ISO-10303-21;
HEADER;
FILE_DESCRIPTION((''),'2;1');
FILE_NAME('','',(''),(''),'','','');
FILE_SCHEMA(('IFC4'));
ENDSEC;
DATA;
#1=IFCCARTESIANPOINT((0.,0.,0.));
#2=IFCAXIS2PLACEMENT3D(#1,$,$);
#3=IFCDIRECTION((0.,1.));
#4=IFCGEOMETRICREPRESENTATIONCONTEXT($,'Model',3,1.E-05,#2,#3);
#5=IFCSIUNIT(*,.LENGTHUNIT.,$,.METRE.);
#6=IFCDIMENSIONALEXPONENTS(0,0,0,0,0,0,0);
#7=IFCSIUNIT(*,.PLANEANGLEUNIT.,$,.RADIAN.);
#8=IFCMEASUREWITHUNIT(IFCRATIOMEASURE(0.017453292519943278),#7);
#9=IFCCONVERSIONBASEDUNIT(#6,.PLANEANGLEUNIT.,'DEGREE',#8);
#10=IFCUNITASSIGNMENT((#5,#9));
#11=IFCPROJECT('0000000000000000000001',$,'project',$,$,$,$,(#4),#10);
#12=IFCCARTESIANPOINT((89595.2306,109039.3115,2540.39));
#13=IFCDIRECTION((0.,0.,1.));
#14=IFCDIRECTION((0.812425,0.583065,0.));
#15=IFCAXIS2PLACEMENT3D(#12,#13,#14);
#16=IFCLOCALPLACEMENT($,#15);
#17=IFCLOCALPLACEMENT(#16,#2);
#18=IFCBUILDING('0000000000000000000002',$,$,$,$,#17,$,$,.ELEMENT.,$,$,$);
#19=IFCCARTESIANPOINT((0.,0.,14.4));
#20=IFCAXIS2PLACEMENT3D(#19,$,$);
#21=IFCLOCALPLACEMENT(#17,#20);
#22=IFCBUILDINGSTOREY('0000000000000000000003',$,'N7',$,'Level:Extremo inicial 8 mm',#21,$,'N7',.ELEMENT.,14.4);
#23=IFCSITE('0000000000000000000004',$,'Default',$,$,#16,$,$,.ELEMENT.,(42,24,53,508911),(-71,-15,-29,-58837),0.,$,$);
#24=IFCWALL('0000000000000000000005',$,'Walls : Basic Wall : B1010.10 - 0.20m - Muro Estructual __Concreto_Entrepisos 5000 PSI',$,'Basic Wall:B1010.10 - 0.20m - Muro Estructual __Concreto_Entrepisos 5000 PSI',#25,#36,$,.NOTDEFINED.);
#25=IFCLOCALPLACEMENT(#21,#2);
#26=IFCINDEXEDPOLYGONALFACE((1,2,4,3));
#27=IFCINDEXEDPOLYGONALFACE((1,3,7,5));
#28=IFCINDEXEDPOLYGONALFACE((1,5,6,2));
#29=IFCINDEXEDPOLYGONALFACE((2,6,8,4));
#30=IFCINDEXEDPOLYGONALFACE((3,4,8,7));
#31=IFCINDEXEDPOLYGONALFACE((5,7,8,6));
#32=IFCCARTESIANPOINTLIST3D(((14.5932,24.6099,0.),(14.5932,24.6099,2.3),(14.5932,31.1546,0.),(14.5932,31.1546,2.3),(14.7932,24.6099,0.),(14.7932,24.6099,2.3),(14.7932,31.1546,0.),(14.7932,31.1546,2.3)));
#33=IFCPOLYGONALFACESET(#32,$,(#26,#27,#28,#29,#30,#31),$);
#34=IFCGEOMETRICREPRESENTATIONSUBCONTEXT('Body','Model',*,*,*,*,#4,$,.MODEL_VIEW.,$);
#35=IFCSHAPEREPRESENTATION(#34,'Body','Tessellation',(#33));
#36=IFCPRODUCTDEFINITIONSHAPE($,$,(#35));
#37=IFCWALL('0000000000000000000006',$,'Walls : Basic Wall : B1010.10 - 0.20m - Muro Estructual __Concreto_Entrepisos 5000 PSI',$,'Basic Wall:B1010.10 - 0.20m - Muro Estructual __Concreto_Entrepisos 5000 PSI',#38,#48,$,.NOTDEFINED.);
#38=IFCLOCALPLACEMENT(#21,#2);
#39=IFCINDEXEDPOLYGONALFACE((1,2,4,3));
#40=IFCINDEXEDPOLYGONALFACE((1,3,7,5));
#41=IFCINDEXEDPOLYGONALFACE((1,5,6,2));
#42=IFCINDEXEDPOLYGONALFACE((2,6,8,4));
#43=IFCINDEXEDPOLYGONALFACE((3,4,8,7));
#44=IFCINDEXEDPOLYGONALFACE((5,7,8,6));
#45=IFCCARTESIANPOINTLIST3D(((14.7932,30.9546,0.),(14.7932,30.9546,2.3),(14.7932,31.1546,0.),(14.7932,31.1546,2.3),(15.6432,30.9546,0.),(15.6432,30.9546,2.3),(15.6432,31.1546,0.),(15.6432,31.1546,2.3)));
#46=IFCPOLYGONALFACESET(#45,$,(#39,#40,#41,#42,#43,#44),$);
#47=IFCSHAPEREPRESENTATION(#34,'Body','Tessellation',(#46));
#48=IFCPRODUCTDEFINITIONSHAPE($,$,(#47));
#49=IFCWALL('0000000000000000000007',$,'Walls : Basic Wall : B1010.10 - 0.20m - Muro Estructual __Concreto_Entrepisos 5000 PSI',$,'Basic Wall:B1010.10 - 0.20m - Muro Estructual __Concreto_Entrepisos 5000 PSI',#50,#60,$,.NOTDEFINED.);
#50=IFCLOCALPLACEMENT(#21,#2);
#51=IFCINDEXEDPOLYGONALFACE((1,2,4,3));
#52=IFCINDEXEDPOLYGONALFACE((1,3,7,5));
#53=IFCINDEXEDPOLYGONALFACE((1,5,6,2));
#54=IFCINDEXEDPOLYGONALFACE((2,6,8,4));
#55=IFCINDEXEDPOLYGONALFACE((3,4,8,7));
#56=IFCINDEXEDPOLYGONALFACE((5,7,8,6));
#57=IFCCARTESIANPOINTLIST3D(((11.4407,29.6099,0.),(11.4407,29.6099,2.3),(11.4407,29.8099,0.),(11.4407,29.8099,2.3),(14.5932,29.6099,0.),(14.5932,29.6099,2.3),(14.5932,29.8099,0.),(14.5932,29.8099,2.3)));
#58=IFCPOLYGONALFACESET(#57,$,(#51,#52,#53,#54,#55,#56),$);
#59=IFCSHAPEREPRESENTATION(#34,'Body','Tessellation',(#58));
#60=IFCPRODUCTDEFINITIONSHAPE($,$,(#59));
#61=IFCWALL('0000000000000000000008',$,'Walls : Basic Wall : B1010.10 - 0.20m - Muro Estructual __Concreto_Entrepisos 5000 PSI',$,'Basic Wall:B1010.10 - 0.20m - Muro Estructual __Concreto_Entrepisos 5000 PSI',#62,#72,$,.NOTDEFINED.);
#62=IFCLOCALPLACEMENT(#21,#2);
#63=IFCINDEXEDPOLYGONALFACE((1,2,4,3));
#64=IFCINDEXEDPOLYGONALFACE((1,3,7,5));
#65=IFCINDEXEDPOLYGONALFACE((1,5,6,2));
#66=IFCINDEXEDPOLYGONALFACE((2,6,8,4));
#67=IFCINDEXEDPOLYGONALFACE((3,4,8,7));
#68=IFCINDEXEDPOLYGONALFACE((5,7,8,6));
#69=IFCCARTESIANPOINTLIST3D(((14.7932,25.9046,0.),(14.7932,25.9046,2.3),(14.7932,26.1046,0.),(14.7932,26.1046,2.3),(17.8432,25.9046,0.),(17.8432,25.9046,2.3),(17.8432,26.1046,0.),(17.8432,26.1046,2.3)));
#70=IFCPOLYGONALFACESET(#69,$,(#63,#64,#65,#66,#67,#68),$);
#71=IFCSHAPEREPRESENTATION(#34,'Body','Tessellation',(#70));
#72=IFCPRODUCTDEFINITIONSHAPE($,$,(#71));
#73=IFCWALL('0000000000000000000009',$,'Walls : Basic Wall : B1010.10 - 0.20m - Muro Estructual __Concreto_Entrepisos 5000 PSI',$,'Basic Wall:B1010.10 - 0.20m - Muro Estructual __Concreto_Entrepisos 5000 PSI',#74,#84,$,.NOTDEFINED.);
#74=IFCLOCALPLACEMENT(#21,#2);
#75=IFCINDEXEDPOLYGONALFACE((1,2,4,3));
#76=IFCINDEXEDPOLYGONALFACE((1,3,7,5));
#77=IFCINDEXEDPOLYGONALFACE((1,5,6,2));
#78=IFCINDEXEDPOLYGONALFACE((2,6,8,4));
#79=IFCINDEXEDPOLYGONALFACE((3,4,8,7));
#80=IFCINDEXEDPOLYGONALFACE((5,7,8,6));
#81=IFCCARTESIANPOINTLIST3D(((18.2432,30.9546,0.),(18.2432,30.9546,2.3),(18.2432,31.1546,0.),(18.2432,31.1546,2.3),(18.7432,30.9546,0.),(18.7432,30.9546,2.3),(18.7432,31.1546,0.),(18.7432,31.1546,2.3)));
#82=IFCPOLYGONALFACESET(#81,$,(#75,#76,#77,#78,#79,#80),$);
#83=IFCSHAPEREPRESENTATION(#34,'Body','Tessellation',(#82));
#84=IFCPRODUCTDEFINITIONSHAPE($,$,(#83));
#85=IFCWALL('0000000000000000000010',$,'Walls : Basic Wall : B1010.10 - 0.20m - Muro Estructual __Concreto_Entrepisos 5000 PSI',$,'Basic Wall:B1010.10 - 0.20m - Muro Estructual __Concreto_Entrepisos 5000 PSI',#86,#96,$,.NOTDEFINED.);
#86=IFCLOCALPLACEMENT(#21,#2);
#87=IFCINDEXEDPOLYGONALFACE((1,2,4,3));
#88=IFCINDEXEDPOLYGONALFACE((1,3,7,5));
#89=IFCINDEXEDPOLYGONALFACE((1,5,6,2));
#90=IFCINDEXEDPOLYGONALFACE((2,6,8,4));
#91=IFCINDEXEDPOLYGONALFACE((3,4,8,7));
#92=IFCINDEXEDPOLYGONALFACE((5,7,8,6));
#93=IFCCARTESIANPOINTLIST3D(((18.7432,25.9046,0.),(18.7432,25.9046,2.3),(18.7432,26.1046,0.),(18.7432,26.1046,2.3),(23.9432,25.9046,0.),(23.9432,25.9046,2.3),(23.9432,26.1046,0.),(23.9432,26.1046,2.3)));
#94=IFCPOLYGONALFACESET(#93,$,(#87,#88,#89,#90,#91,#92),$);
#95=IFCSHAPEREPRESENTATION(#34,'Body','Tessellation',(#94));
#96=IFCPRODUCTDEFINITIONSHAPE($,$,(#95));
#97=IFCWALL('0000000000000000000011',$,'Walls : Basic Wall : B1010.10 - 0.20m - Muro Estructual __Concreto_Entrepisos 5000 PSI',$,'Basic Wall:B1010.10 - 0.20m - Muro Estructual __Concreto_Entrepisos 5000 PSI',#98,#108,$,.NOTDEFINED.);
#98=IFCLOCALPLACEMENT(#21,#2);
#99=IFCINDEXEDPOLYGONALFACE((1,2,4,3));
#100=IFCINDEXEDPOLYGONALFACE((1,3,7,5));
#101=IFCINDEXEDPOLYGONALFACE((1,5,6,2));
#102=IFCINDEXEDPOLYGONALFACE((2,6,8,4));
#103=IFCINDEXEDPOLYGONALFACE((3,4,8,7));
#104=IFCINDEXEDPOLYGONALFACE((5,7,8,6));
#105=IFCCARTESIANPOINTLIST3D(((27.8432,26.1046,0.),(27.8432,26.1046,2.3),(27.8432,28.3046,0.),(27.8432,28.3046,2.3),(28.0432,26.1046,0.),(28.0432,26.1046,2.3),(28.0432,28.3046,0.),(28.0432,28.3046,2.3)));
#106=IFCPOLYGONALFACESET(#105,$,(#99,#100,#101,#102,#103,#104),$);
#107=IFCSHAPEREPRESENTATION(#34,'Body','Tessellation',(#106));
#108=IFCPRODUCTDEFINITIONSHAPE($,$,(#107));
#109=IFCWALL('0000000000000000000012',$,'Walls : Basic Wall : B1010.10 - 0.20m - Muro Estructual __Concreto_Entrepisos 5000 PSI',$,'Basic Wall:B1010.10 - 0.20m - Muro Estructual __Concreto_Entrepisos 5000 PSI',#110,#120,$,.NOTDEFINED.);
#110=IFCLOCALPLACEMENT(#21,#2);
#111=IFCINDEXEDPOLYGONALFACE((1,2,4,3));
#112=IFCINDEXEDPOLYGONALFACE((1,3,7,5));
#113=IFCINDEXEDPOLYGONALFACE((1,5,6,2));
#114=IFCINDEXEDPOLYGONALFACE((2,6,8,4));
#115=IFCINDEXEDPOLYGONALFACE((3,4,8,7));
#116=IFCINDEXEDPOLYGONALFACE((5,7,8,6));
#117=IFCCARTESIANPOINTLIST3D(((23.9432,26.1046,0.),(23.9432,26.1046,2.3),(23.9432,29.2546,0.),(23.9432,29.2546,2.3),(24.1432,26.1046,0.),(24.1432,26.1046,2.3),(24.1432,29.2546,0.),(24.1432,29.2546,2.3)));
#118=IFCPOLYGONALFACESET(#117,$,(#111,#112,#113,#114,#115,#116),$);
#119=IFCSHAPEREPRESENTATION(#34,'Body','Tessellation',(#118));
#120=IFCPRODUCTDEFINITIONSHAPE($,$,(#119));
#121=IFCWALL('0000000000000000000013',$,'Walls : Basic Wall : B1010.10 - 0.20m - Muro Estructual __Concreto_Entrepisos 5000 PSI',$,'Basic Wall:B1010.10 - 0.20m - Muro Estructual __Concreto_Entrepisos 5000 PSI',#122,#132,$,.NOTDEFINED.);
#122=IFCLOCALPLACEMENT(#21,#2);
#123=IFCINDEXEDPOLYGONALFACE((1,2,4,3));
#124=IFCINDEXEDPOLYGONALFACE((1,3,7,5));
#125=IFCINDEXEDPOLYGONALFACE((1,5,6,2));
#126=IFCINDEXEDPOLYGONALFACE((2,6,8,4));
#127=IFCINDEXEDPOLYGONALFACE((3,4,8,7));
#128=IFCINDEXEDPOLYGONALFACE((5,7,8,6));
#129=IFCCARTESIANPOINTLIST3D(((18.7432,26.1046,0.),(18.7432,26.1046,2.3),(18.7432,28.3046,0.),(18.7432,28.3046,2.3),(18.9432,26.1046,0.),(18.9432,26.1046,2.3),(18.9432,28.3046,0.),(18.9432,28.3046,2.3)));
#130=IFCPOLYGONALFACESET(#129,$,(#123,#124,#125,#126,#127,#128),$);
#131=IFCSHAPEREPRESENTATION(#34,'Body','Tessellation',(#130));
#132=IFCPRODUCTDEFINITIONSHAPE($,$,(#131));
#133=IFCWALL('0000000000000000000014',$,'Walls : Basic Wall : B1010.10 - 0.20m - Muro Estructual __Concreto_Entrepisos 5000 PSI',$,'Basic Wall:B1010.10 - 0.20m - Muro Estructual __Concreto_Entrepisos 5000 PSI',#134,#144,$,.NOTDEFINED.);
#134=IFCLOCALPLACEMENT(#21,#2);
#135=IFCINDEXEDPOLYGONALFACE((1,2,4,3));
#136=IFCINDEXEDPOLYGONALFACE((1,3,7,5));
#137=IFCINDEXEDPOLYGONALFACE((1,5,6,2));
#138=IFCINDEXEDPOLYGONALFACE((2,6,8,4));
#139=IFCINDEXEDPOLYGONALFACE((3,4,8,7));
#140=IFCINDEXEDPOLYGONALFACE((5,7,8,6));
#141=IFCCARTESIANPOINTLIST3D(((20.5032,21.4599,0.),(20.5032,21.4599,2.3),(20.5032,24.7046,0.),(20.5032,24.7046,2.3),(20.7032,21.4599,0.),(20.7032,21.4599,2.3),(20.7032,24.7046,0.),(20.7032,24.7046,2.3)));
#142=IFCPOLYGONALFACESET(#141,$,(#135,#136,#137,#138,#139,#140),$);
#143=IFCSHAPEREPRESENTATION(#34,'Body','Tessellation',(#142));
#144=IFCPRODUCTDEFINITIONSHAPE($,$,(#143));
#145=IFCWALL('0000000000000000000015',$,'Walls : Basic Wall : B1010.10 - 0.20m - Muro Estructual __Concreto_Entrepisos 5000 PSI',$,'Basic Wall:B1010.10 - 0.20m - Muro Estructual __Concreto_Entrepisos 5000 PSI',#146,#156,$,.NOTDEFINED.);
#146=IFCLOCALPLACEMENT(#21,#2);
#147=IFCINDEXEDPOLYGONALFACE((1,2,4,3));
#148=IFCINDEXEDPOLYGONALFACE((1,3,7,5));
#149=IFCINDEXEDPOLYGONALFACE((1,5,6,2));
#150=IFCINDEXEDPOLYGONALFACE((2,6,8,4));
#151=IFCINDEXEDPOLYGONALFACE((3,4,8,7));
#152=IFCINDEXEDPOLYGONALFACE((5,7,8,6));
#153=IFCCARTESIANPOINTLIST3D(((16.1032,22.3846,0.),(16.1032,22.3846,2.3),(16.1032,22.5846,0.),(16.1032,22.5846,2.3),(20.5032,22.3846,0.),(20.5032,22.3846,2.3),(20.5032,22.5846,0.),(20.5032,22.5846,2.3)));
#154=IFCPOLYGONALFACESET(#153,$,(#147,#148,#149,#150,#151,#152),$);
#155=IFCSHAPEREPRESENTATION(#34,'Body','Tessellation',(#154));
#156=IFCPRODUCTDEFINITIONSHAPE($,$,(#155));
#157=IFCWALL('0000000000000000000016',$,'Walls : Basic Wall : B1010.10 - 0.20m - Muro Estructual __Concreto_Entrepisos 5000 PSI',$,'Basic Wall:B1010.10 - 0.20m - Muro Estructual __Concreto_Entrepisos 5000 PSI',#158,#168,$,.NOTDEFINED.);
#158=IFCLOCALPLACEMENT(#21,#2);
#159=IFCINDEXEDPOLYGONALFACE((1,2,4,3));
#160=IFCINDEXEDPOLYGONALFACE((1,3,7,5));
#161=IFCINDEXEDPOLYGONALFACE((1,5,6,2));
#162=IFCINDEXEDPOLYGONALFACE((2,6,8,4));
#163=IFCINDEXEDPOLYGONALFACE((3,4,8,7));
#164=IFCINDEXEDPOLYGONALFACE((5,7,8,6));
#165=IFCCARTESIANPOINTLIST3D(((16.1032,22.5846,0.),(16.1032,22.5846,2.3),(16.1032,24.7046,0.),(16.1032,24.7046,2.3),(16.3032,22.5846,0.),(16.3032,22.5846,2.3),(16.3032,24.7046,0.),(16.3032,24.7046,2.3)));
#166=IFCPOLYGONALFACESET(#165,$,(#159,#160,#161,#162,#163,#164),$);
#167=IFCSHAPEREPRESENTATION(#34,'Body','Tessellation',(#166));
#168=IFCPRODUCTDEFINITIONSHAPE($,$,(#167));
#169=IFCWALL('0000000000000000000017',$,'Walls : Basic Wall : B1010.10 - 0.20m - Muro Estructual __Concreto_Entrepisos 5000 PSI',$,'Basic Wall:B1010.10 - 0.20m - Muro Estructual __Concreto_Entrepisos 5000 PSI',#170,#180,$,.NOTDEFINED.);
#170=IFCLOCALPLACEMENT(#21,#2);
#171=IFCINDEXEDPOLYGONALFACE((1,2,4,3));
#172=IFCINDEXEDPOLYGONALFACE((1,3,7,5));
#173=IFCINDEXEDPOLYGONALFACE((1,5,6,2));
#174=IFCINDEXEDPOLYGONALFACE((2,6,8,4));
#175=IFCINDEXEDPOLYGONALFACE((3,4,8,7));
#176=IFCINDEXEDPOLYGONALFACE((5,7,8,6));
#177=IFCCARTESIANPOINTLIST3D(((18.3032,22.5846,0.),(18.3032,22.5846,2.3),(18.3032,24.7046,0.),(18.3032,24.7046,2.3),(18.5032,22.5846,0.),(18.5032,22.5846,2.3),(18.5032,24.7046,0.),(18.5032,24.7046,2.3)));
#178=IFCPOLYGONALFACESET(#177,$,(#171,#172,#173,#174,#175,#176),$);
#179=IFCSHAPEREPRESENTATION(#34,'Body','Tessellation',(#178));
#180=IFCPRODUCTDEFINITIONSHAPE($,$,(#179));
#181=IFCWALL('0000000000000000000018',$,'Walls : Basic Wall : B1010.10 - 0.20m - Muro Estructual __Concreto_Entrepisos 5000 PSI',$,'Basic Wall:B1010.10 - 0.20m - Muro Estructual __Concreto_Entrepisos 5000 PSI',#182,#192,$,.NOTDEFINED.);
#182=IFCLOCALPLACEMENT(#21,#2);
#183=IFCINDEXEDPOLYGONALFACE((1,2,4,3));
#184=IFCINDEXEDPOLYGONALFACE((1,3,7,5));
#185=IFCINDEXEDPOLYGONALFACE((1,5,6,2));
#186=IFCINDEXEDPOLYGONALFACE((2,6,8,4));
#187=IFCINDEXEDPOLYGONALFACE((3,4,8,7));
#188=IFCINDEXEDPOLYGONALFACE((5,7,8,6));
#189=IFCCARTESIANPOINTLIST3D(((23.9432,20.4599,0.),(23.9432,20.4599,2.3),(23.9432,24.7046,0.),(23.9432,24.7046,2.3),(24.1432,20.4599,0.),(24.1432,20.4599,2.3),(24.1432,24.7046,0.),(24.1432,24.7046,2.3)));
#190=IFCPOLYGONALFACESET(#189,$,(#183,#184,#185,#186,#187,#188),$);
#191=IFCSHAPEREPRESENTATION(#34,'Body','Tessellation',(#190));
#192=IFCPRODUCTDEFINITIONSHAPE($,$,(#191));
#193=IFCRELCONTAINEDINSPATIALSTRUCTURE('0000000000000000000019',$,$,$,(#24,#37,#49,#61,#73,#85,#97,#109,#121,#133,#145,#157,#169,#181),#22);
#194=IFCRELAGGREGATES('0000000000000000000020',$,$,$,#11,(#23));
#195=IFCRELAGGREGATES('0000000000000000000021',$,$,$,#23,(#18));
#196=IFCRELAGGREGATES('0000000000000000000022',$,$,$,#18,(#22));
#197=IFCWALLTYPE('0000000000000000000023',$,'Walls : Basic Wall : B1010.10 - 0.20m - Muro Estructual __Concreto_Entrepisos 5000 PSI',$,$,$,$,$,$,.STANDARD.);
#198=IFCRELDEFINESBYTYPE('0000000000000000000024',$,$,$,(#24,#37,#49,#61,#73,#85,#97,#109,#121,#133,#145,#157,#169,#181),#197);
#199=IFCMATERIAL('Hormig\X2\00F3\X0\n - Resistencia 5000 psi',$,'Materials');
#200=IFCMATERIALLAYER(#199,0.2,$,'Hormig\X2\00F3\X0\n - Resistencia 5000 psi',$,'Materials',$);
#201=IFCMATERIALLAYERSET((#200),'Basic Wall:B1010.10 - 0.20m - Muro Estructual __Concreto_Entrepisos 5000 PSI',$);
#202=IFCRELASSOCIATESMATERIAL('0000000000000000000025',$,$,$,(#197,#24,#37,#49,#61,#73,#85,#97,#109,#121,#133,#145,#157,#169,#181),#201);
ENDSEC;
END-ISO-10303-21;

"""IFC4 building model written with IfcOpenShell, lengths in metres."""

from ifc_helpers import new_model, entity, si_unit, converted_unit, direction, frame, frame_2d, origin, place, context, subcontext, project, spatial, rectangle, extrude, material, layer, layer_set, layer_usage, type_object, element, save


model = new_model("IFC4")

# Units and contexts
model_context = context("Model", 3, precision=1e-05, world=origin(), true_north=direction((0.0, 1.0)))
body_context = subcontext(model_context, "Body", "Model", "MODEL_VIEW")
ifc_project = project(units=[si_unit("LENGTHUNIT", "METRE"), converted_unit("PLANEANGLEUNIT", "DEGREE", entity("IfcRatioMeasure", 0.017453292519943278), si_unit("PLANEANGLEUNIT", "RADIAN"), dimensions=[0, 0, 0, 0, 0, 0, 0])], contexts=[model_context])

# Site, building, storey
site_placement = place(None, frame((89595.2306, 109039.3115, 2540.39), z_axis=(0.0, 0.0, 1.0), x_axis=(0.812425, 0.583065, 0.0)))
site = spatial("IfcSite", under=ifc_project, at=site_placement, Name="Default", CompositionType="ELEMENT", RefLatitude=(42, 24, 53, 508911), RefLongitude=(-71, -15, -29, -58837), RefElevation=0.0)
building_placement = place(site_placement, origin())
building = spatial("IfcBuilding", under=site, at=building_placement, CompositionType="ELEMENT")
storey_placement = place(building_placement, frame((0.0, 0.0, 14.4)))
storey = spatial("IfcBuildingStorey", under=building, at=storey_placement, Name="N7", ObjectType="Level:Extremo inicial 8 mm", LongName="N7", CompositionType="ELEMENT", Elevation=14.4)

# Walls
ifc_material_1 = material(Name="Hormigón - Resistencia 5000 psi", Category="Materials")
ifc_layer_1 = layer(ifc_material_1, 0.2, Name="Hormigón - Resistencia 5000 psi", Category="Materials")
ifc_layer_set_1 = layer_set([ifc_layer_1], Name="Basic Wall:B1010.10 - 0.20m - Muro Estructual __Concreto_Entrepisos 5000 PSI")
ifc_layer_usage_1 = layer_usage(ifc_layer_set_1, "AXIS2", "NEGATIVE", 0.1)
wall_type_1 = type_object("IfcWallType", Name="Walls : Basic Wall : B1010.10 - 0.20m - Muro Estructual __Concreto_Entrepisos 5000 PSI", PredefinedType="STANDARD", material=ifc_layer_set_1)
wall_1_placement = place(storey_placement, frame((14.6932, 24.6099, 0.0), z_axis=(0.0, 0.0, 1.0), x_axis=(0.0, 1.0, 0.0)))
element("IfcWall", 1, at=wall_1_placement, inside=storey, type_object=wall_type_1, material=ifc_layer_usage_1, Name="Walls : Basic Wall : B1010.10 - 0.20m - Muro Estructual __Concreto_Entrepisos 5000 PSI", ObjectType="Basic Wall:B1010.10 - 0.20m - Muro Estructual __Concreto_Entrepisos 5000 PSI", PredefinedType="NOTDEFINED", context=body_context, shape_type="SweptSolid", body=[
    extrude(rectangle(XDim=6.5447, YDim=0.2, at=frame_2d((3.2724, 0.0), x_axis=(-1.0, 0.0))), origin(), (0.0, 0.0, 1.0), 2.3),
])
ifc_layer_usage_2 = layer_usage(ifc_layer_set_1, "AXIS2", "NEGATIVE", 0.1)
wall_2_placement = place(storey_placement, frame((15.6432, 31.0546, 0.0), z_axis=(0.0, 0.0, 1.0), x_axis=(-1.0, 0.0, 0.0)))
element("IfcWall", 2, at=wall_2_placement, inside=storey, type_object=wall_type_1, material=ifc_layer_usage_2, Name="Walls : Basic Wall : B1010.10 - 0.20m - Muro Estructual __Concreto_Entrepisos 5000 PSI", ObjectType="Basic Wall:B1010.10 - 0.20m - Muro Estructual __Concreto_Entrepisos 5000 PSI", PredefinedType="NOTDEFINED", context=body_context, shape_type="SweptSolid", body=[
    extrude(rectangle(XDim=0.85, YDim=0.2, at=frame_2d((0.425, 0.0), x_axis=(-1.0, 0.0))), origin(), (0.0, 0.0, 1.0), 2.3),
])
ifc_layer_usage_3 = layer_usage(ifc_layer_set_1, "AXIS2", "NEGATIVE", 0.1)
wall_3_placement = place(storey_placement, frame((11.4407, 29.7099, 0.0)))
element("IfcWall", 3, at=wall_3_placement, inside=storey, type_object=wall_type_1, material=ifc_layer_usage_3, Name="Walls : Basic Wall : B1010.10 - 0.20m - Muro Estructual __Concreto_Entrepisos 5000 PSI", ObjectType="Basic Wall:B1010.10 - 0.20m - Muro Estructual __Concreto_Entrepisos 5000 PSI", PredefinedType="NOTDEFINED", context=body_context, shape_type="SweptSolid", body=[
    extrude(rectangle(XDim=3.1525, YDim=0.2, at=frame_2d((1.5763, 0.0), x_axis=(-1.0, 0.0))), origin(), (0.0, 0.0, 1.0), 2.3),
])
ifc_layer_usage_4 = layer_usage(ifc_layer_set_1, "AXIS2", "NEGATIVE", 0.1)
wall_4_placement = place(storey_placement, frame((17.8432, 26.0046, 0.0), z_axis=(0.0, 0.0, 1.0), x_axis=(-1.0, 0.0, 0.0)))
element("IfcWall", 4, at=wall_4_placement, inside=storey, type_object=wall_type_1, material=ifc_layer_usage_4, Name="Walls : Basic Wall : B1010.10 - 0.20m - Muro Estructual __Concreto_Entrepisos 5000 PSI", ObjectType="Basic Wall:B1010.10 - 0.20m - Muro Estructual __Concreto_Entrepisos 5000 PSI", PredefinedType="NOTDEFINED", context=body_context, shape_type="SweptSolid", body=[
    extrude(rectangle(XDim=3.05, YDim=0.2, at=frame_2d((1.525, 0.0), x_axis=(-1.0, 0.0))), origin(), (0.0, 0.0, 1.0), 2.3),
])
ifc_layer_usage_5 = layer_usage(ifc_layer_set_1, "AXIS2", "NEGATIVE", 0.1)
wall_5_placement = place(storey_placement, frame((18.7432, 31.0546, 0.0), z_axis=(0.0, 0.0, 1.0), x_axis=(-1.0, 0.0, 0.0)))
element("IfcWall", 5, at=wall_5_placement, inside=storey, type_object=wall_type_1, material=ifc_layer_usage_5, Name="Walls : Basic Wall : B1010.10 - 0.20m - Muro Estructual __Concreto_Entrepisos 5000 PSI", ObjectType="Basic Wall:B1010.10 - 0.20m - Muro Estructual __Concreto_Entrepisos 5000 PSI", PredefinedType="NOTDEFINED", context=body_context, shape_type="SweptSolid", body=[
    extrude(rectangle(XDim=0.5, YDim=0.2, at=frame_2d((0.25, 0.0), x_axis=(-1.0, 0.0))), origin(), (0.0, 0.0, 1.0), 2.3),
])
ifc_layer_usage_6 = layer_usage(ifc_layer_set_1, "AXIS2", "NEGATIVE", 0.1)
wall_6_placement = place(storey_placement, frame((18.7432, 26.0046, 0.0)))
element("IfcWall", 6, at=wall_6_placement, inside=storey, type_object=wall_type_1, material=ifc_layer_usage_6, Name="Walls : Basic Wall : B1010.10 - 0.20m - Muro Estructual __Concreto_Entrepisos 5000 PSI", ObjectType="Basic Wall:B1010.10 - 0.20m - Muro Estructual __Concreto_Entrepisos 5000 PSI", PredefinedType="NOTDEFINED", context=body_context, shape_type="SweptSolid", body=[
    extrude(rectangle(XDim=5.2, YDim=0.2, at=frame_2d((2.6, 0.0), x_axis=(-1.0, 0.0))), origin(), (0.0, 0.0, 1.0), 2.3),
])
ifc_layer_usage_7 = layer_usage(ifc_layer_set_1, "AXIS2", "NEGATIVE", 0.1)
wall_7_placement = place(storey_placement, frame((27.9432, 28.3046, 0.0), z_axis=(0.0, 0.0, 1.0), x_axis=(0.0, -1.0, 0.0)))
element("IfcWall", 7, at=wall_7_placement, inside=storey, type_object=wall_type_1, material=ifc_layer_usage_7, Name="Walls : Basic Wall : B1010.10 - 0.20m - Muro Estructual __Concreto_Entrepisos 5000 PSI", ObjectType="Basic Wall:B1010.10 - 0.20m - Muro Estructual __Concreto_Entrepisos 5000 PSI", PredefinedType="NOTDEFINED", context=body_context, shape_type="SweptSolid", body=[
    extrude(rectangle(XDim=2.2, YDim=0.2, at=frame_2d((1.1, 0.0), x_axis=(-1.0, 0.0))), origin(), (0.0, 0.0, 1.0), 2.3),
])
ifc_layer_usage_8 = layer_usage(ifc_layer_set_1, "AXIS2", "NEGATIVE", 0.1)
wall_8_placement = place(storey_placement, frame((24.0432, 26.1046, 0.0), z_axis=(0.0, 0.0, 1.0), x_axis=(0.0, 1.0, 0.0)))
element("IfcWall", 8, at=wall_8_placement, inside=storey, type_object=wall_type_1, material=ifc_layer_usage_8, Name="Walls : Basic Wall : B1010.10 - 0.20m - Muro Estructual __Concreto_Entrepisos 5000 PSI", ObjectType="Basic Wall:B1010.10 - 0.20m - Muro Estructual __Concreto_Entrepisos 5000 PSI", PredefinedType="NOTDEFINED", context=body_context, shape_type="SweptSolid", body=[
    extrude(rectangle(XDim=3.15, YDim=0.2, at=frame_2d((1.575, 0.0), x_axis=(-1.0, 0.0))), origin(), (0.0, 0.0, 1.0), 2.3),
])
ifc_layer_usage_9 = layer_usage(ifc_layer_set_1, "AXIS2", "NEGATIVE", 0.1)
wall_9_placement = place(storey_placement, frame((18.8432, 28.3046, 0.0), z_axis=(0.0, 0.0, 1.0), x_axis=(0.0, -1.0, 0.0)))
element("IfcWall", 9, at=wall_9_placement, inside=storey, type_object=wall_type_1, material=ifc_layer_usage_9, Name="Walls : Basic Wall : B1010.10 - 0.20m - Muro Estructual __Concreto_Entrepisos 5000 PSI", ObjectType="Basic Wall:B1010.10 - 0.20m - Muro Estructual __Concreto_Entrepisos 5000 PSI", PredefinedType="NOTDEFINED", context=body_context, shape_type="SweptSolid", body=[
    extrude(rectangle(XDim=2.2, YDim=0.2, at=frame_2d((1.1, 0.0), x_axis=(-1.0, 0.0))), origin(), (0.0, 0.0, 1.0), 2.3),
])
ifc_layer_usage_10 = layer_usage(ifc_layer_set_1, "AXIS2", "NEGATIVE", 0.1)
wall_10_placement = place(storey_placement, frame((20.6032, 21.4599, 0.0), z_axis=(0.0, 0.0, 1.0), x_axis=(0.0, 1.0, 0.0)))
element("IfcWall", 10, at=wall_10_placement, inside=storey, type_object=wall_type_1, material=ifc_layer_usage_10, Name="Walls : Basic Wall : B1010.10 - 0.20m - Muro Estructual __Concreto_Entrepisos 5000 PSI", ObjectType="Basic Wall:B1010.10 - 0.20m - Muro Estructual __Concreto_Entrepisos 5000 PSI", PredefinedType="NOTDEFINED", context=body_context, shape_type="SweptSolid", body=[
    extrude(rectangle(XDim=3.2447, YDim=0.2, at=frame_2d((1.6224, 0.0), x_axis=(-1.0, 0.0))), origin(), (0.0, 0.0, 1.0), 2.3),
])
ifc_layer_usage_11 = layer_usage(ifc_layer_set_1, "AXIS2", "NEGATIVE", 0.1)
wall_11_placement = place(storey_placement, frame((20.5032, 22.4846, 0.0), z_axis=(0.0, 0.0, 1.0), x_axis=(-1.0, 0.0, 0.0)))
element("IfcWall", 11, at=wall_11_placement, inside=storey, type_object=wall_type_1, material=ifc_layer_usage_11, Name="Walls : Basic Wall : B1010.10 - 0.20m - Muro Estructual __Concreto_Entrepisos 5000 PSI", ObjectType="Basic Wall:B1010.10 - 0.20m - Muro Estructual __Concreto_Entrepisos 5000 PSI", PredefinedType="NOTDEFINED", context=body_context, shape_type="SweptSolid", body=[
    extrude(rectangle(XDim=4.4, YDim=0.2, at=frame_2d((2.2, 0.0), x_axis=(-1.0, 0.0))), origin(), (0.0, 0.0, 1.0), 2.3),
])
ifc_layer_usage_12 = layer_usage(ifc_layer_set_1, "AXIS2", "NEGATIVE", 0.1)
wall_12_placement = place(storey_placement, frame((16.2032, 22.5846, 0.0), z_axis=(0.0, 0.0, 1.0), x_axis=(0.0, 1.0, 0.0)))
element("IfcWall", 12, at=wall_12_placement, inside=storey, type_object=wall_type_1, material=ifc_layer_usage_12, Name="Walls : Basic Wall : B1010.10 - 0.20m - Muro Estructual __Concreto_Entrepisos 5000 PSI", ObjectType="Basic Wall:B1010.10 - 0.20m - Muro Estructual __Concreto_Entrepisos 5000 PSI", PredefinedType="NOTDEFINED", context=body_context, shape_type="SweptSolid", body=[
    extrude(rectangle(XDim=2.12, YDim=0.2, at=frame_2d((1.06, 0.0), x_axis=(-1.0, 0.0))), origin(), (0.0, 0.0, 1.0), 2.3),
])
ifc_layer_usage_13 = layer_usage(ifc_layer_set_1, "AXIS2", "NEGATIVE", 0.1)
wall_13_placement = place(storey_placement, frame((18.4032, 24.7046, 0.0), z_axis=(0.0, 0.0, 1.0), x_axis=(0.0, -1.0, 0.0)))
element("IfcWall", 13, at=wall_13_placement, inside=storey, type_object=wall_type_1, material=ifc_layer_usage_13, Name="Walls : Basic Wall : B1010.10 - 0.20m - Muro Estructual __Concreto_Entrepisos 5000 PSI", ObjectType="Basic Wall:B1010.10 - 0.20m - Muro Estructual __Concreto_Entrepisos 5000 PSI", PredefinedType="NOTDEFINED", context=body_context, shape_type="SweptSolid", body=[
    extrude(rectangle(XDim=2.12, YDim=0.2, at=frame_2d((1.06, 0.0), x_axis=(-1.0, 0.0))), origin(), (0.0, 0.0, 1.0), 2.3),
])
ifc_layer_usage_14 = layer_usage(ifc_layer_set_1, "AXIS2", "NEGATIVE", 0.1)
wall_14_placement = place(storey_placement, frame((24.0432, 20.4599, 0.0), z_axis=(0.0, 0.0, 1.0), x_axis=(0.0, 1.0, 0.0)))
element("IfcWall", 14, at=wall_14_placement, inside=storey, type_object=wall_type_1, material=ifc_layer_usage_14, Name="Walls : Basic Wall : B1010.10 - 0.20m - Muro Estructual __Concreto_Entrepisos 5000 PSI", ObjectType="Basic Wall:B1010.10 - 0.20m - Muro Estructual __Concreto_Entrepisos 5000 PSI", PredefinedType="NOTDEFINED", context=body_context, shape_type="SweptSolid", body=[
    extrude(rectangle(XDim=4.2447, YDim=0.2, at=frame_2d((2.1224, 0.0), x_axis=(-1.0, 0.0))), origin(), (0.0, 0.0, 1.0), 2.3),
])

save(model, "model.ifc")
